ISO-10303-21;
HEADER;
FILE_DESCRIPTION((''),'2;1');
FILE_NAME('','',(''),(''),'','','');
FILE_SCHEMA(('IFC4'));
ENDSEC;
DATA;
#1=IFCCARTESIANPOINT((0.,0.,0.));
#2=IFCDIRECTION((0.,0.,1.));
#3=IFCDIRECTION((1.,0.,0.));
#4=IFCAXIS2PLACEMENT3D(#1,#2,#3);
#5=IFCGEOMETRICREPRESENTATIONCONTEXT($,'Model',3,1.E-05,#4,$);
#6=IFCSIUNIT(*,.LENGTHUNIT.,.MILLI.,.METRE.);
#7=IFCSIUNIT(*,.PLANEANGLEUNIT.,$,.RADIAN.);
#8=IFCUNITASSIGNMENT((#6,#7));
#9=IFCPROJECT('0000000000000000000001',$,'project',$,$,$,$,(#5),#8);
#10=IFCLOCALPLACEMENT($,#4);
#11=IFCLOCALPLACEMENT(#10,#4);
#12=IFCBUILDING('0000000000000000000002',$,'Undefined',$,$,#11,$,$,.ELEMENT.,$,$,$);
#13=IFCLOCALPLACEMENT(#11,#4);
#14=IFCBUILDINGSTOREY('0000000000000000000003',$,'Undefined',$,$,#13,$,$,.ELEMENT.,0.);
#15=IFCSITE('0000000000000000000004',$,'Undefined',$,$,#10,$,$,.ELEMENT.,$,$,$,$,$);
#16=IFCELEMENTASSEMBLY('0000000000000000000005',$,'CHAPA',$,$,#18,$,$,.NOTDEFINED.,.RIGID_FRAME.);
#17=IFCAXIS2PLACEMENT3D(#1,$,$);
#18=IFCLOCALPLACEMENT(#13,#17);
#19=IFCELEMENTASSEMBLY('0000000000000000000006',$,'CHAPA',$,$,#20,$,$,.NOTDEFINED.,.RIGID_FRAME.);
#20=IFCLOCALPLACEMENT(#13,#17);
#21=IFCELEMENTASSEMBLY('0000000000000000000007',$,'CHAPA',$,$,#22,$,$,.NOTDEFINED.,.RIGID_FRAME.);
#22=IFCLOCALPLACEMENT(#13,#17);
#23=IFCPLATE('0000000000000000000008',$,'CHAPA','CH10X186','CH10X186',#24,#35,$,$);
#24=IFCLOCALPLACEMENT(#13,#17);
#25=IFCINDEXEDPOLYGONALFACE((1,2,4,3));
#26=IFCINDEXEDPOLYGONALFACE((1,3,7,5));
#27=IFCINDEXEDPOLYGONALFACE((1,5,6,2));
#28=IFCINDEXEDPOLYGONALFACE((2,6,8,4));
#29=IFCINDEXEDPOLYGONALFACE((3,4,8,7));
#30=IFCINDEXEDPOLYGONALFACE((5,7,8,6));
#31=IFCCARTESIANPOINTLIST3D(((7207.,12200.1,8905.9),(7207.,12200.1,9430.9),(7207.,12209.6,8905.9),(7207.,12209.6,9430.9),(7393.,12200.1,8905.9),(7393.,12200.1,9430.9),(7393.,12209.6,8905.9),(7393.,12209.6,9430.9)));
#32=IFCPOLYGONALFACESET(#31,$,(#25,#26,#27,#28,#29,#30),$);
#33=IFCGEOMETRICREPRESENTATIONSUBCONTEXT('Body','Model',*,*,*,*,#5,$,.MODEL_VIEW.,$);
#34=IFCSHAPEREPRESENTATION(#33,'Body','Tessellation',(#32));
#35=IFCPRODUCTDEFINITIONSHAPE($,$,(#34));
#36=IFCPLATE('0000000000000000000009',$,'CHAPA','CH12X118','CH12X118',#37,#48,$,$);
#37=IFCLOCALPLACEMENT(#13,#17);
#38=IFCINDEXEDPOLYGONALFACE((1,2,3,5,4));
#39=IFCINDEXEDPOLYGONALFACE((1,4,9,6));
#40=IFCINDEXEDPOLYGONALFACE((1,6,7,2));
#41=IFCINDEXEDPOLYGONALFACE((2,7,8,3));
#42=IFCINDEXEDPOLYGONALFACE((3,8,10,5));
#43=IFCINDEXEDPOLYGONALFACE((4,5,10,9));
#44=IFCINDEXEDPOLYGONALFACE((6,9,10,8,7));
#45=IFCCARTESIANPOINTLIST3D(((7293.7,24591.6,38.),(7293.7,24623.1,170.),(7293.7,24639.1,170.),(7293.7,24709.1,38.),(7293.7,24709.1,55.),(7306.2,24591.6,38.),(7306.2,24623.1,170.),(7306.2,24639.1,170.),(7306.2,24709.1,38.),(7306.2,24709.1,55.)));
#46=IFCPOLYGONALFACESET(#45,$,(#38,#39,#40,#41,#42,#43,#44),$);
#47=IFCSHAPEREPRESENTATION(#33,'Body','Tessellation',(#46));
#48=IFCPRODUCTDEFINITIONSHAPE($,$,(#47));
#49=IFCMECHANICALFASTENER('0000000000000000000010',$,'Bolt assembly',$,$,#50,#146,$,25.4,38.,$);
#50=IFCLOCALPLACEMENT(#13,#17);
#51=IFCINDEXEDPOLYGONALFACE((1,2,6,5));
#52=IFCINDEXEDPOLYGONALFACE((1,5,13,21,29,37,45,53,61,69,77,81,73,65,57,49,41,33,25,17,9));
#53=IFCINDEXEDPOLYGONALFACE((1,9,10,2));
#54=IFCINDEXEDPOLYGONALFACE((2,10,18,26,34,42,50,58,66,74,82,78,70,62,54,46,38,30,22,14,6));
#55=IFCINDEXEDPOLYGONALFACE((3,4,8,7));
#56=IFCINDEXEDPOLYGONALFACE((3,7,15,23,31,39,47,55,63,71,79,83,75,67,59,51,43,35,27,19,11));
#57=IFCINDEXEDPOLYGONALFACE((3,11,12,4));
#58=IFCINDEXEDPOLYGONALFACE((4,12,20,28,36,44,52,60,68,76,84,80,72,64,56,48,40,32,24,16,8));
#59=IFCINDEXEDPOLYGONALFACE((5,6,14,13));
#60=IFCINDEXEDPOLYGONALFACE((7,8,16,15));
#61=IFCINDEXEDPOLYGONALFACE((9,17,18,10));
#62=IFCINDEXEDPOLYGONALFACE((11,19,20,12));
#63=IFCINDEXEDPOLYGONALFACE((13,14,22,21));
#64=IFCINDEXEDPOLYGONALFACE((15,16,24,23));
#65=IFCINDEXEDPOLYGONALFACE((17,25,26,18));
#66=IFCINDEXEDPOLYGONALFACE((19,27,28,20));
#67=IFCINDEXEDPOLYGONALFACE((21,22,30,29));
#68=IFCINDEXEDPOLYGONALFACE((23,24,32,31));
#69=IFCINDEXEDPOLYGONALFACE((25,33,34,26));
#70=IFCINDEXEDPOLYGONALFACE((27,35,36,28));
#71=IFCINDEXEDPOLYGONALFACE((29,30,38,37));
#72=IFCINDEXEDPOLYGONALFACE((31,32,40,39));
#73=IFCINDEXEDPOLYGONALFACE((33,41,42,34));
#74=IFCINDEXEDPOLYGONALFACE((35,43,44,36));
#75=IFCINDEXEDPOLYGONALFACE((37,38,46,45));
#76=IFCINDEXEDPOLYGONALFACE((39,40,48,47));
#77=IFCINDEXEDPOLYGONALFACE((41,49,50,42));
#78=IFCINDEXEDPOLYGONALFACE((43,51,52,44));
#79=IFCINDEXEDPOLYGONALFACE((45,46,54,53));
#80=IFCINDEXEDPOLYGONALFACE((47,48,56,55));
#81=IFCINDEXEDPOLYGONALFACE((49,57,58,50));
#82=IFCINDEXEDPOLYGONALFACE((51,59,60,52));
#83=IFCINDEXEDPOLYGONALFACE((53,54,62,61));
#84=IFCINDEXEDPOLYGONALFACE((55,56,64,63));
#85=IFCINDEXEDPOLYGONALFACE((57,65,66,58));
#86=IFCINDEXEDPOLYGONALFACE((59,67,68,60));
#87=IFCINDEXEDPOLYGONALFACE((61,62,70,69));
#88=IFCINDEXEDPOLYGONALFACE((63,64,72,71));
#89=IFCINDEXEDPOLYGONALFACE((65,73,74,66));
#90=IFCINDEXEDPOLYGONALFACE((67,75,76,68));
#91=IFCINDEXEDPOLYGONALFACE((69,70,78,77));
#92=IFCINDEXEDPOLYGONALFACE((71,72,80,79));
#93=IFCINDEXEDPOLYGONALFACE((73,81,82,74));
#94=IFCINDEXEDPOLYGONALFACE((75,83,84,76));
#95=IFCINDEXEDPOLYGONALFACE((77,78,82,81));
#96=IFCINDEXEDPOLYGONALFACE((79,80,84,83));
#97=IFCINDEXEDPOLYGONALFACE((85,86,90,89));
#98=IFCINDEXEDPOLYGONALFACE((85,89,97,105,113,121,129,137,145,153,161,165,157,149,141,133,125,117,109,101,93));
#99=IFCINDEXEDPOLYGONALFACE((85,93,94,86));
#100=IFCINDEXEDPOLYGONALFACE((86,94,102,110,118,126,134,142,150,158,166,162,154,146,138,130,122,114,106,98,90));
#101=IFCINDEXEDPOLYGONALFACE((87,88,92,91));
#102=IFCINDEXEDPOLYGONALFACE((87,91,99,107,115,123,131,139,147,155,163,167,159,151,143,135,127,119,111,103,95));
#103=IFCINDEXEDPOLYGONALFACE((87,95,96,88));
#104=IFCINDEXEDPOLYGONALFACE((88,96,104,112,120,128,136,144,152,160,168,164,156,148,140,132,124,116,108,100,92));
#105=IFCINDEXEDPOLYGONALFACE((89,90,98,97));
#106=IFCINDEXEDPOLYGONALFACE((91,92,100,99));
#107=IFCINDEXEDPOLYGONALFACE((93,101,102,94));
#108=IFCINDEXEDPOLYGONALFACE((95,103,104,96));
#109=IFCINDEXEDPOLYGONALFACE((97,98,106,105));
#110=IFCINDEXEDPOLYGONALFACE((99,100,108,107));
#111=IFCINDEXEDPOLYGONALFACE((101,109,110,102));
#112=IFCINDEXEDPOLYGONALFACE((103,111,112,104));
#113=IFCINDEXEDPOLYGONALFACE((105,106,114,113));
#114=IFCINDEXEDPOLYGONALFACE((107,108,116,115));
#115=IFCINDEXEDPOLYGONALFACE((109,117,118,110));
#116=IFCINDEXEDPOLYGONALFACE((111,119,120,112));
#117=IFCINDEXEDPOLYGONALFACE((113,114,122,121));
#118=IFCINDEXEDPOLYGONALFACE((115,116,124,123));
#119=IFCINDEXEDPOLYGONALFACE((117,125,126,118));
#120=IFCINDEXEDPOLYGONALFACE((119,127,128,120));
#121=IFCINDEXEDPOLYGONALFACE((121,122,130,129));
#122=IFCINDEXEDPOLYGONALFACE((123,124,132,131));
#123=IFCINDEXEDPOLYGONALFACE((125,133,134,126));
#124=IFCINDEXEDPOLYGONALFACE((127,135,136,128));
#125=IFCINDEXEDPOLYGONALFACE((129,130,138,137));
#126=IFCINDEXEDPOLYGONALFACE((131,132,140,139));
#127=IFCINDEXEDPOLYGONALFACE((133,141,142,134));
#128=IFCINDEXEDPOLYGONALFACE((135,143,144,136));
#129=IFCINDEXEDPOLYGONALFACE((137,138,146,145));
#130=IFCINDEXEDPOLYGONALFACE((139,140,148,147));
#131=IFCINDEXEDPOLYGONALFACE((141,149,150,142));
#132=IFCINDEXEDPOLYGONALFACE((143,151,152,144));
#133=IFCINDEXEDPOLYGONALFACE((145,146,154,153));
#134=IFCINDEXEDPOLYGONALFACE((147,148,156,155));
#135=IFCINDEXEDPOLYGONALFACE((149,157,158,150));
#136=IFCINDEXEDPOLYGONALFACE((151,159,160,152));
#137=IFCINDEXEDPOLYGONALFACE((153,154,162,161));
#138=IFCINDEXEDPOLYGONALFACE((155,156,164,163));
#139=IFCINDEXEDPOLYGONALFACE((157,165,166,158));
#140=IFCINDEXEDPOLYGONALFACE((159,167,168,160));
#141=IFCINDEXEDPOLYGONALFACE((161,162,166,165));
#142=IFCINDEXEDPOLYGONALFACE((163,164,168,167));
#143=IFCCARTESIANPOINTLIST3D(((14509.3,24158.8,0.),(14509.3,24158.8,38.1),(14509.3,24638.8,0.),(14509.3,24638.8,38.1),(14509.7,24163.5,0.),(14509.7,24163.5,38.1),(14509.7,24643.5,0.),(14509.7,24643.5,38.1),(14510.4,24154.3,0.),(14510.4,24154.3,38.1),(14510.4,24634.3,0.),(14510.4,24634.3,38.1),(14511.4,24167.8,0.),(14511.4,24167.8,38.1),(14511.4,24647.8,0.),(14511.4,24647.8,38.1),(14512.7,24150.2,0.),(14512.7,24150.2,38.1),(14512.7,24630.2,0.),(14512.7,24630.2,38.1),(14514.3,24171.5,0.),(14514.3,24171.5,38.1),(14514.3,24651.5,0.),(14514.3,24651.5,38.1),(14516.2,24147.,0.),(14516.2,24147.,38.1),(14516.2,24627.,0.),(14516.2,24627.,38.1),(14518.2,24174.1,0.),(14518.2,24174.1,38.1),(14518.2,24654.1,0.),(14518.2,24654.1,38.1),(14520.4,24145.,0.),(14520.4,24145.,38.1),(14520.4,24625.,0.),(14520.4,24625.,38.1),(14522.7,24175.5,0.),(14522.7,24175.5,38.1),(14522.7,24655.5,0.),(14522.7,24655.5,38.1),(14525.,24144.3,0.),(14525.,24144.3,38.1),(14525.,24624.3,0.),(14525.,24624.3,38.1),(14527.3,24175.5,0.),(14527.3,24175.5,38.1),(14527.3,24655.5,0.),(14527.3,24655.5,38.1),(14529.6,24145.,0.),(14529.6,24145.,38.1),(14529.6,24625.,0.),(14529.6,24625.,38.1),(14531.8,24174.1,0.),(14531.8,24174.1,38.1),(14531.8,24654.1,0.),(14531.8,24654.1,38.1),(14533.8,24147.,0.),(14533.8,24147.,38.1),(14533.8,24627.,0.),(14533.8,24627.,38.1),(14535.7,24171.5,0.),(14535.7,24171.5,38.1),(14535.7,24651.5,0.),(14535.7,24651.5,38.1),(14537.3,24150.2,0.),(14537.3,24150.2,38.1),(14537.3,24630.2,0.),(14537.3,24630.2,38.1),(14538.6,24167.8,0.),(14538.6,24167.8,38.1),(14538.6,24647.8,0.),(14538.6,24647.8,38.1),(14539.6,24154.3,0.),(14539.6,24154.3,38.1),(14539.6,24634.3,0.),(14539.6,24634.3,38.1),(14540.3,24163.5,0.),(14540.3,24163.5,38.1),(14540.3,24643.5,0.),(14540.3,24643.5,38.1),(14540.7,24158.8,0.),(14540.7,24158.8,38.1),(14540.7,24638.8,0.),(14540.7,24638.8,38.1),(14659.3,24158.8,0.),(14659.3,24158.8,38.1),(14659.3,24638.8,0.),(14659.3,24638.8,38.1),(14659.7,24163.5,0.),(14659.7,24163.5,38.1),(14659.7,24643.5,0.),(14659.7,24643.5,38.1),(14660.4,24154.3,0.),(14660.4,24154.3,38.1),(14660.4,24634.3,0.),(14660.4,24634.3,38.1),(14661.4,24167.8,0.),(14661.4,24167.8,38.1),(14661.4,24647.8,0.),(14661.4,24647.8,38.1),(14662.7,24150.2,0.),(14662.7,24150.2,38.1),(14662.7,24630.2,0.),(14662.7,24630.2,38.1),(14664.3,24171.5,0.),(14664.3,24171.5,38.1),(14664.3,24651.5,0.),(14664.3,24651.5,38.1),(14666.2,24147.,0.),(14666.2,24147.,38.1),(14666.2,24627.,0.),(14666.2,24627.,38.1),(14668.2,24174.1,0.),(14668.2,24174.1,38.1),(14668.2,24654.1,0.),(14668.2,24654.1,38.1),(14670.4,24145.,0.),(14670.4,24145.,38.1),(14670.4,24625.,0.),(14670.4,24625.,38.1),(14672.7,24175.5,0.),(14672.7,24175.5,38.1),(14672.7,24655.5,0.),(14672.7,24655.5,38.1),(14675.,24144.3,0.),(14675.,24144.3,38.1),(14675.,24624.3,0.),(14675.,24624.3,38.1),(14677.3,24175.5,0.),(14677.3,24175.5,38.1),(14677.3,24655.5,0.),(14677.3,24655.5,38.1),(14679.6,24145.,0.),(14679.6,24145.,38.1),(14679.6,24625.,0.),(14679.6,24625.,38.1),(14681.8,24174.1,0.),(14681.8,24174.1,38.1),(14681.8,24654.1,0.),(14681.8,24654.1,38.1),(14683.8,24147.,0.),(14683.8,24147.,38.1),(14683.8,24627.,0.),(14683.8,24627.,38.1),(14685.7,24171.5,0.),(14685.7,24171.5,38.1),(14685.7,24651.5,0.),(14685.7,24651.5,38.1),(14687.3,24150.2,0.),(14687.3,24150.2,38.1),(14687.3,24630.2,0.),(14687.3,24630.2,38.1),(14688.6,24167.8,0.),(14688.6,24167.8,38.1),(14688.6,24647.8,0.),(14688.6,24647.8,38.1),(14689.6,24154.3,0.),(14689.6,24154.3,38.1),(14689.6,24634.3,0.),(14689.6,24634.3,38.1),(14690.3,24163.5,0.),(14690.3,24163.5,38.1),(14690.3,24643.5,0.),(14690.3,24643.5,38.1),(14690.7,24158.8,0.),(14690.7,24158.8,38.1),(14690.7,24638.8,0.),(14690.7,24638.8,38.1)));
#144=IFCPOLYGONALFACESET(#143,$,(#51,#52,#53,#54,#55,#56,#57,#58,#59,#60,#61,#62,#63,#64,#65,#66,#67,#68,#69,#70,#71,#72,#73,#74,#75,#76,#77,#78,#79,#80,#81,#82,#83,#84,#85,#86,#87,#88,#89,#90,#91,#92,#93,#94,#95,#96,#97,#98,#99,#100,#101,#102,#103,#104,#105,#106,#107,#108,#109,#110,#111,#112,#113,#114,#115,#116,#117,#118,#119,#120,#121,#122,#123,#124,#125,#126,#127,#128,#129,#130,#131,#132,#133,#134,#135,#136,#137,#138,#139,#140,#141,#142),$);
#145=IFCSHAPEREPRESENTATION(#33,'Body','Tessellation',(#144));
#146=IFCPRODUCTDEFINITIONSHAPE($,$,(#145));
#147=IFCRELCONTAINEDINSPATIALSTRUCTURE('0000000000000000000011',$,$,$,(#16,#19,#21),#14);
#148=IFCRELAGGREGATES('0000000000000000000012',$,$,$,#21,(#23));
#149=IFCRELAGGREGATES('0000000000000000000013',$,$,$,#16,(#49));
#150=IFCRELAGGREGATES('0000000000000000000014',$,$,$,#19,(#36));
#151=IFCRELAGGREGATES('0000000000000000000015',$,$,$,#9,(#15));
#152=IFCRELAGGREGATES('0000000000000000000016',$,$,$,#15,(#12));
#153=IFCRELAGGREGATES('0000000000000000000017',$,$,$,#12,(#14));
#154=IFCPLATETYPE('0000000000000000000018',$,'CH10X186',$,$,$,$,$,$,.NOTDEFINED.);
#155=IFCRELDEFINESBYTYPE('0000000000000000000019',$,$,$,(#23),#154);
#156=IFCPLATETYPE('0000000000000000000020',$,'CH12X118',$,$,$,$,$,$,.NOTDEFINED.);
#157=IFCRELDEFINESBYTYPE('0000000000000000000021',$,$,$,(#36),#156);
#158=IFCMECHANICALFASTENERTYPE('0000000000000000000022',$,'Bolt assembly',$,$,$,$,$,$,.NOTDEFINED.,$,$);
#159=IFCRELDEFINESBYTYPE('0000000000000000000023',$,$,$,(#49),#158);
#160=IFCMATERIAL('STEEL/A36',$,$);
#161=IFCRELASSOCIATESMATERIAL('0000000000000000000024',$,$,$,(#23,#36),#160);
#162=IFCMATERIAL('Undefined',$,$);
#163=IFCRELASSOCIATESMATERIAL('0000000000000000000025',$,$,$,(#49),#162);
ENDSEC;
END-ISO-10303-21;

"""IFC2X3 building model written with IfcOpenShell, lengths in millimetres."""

from ifc_helpers import new_model, si_unit, frame, origin_with_axes, origin_2d_with_axis, place, context, subcontext, project, spatial, polyline, circle, outline, extrude, source, transform, mapped, material, type_object, element, aggregate, save


model = new_model("IFC2X3")

# Units and contexts
model_context = context("Model", 3, precision=1e-05, world=origin_with_axes())
body_context = subcontext(model_context, "Body", "Model", "MODEL_VIEW")
ifc_project = project(units=[si_unit("LENGTHUNIT", "METRE", prefix="MILLI"), si_unit("PLANEANGLEUNIT", "RADIAN")], contexts=[model_context])

# Site, building, storey
site_placement = place(None, origin_with_axes())
site = spatial("IfcSite", under=ifc_project, at=site_placement, Name="Undefined", CompositionType="ELEMENT")
building_placement = place(site_placement, origin_with_axes())
building = spatial("IfcBuilding", under=site, at=building_placement, Name="Undefined", CompositionType="ELEMENT")
storey_placement = place(building_placement, origin_with_axes())
storey = spatial("IfcBuildingStorey", under=building, at=storey_placement, Name="Undefined", CompositionType="ELEMENT", Elevation=0.0)

# Element assemblies
assembly_1_placement = place(storey_placement, origin_with_axes())
assembly_1 = element("IfcElementAssembly", 1, at=assembly_1_placement, inside=storey, Name="CHAPA", AssemblyPlace="NOTDEFINED", PredefinedType="RIGID_FRAME")
assembly_2_placement = place(storey_placement, origin_with_axes())
assembly_2 = element("IfcElementAssembly", 2, at=assembly_2_placement, inside=storey, Name="CHAPA", AssemblyPlace="NOTDEFINED", PredefinedType="RIGID_FRAME")

# Shared definitions
ifc_material_1 = material(Name="STEEL/A36")

# Element assembly
assembly_3_placement = place(storey_placement, origin_with_axes())
assembly_3 = element("IfcElementAssembly", 3, at=assembly_3_placement, inside=storey, Name="CHAPA", AssemblyPlace="NOTDEFINED", PredefinedType="RIGID_FRAME")

# Plates
plate_type_1 = type_object("IfcPlateType", Name="CH10X186", PredefinedType="NOTDEFINED")
plate_1_placement = place(assembly_3_placement, frame((7393.0, 12204.8, 9430.9), z_axis=(0.0, -1.0, 0.0), x_axis=(-1.0, 0.0, 0.0)))
plate_1 = element("IfcPlate", 4, at=plate_1_placement, type_object=plate_type_1, material=ifc_material_1, Name="CHAPA", Description="CH10X186", ObjectType="CH10X186", context=body_context, shape_type="SweptSolid", body=[
    extrude(outline(polyline([(0.0, 0.0), (186.0, 0.0), (186.0, 525.0), (0.0, 525.0), (0.0, 0.0)])), frame((0.0, 0.0, -4.8), z_axis=(0.0, 0.0, 1.0), x_axis=(1.0, 0.0, 0.0)), (0.0, 0.0, 1.0), 9.5),
])
aggregate(assembly_3, [plate_1])
plate_type_2 = type_object("IfcPlateType", Name="CH12X118", PredefinedType="NOTDEFINED")
plate_2_placement = place(assembly_2_placement, frame((7300.0, 24709.1, 38.0), z_axis=(-1.0, 0.0, 0.0), x_axis=(0.0, -1.0, 0.0)))
plate_2 = element("IfcPlate", 5, at=plate_2_placement, type_object=plate_type_2, material=ifc_material_1, Name="CHAPA", Description="CH12X118", ObjectType="CH12X118", context=body_context, shape_type="SweptSolid", body=[
    extrude(outline(polyline([(0.0, 0.0), (117.5, 0.0), (85.9, 132.0), (70.0, 132.0), (0.0, 17.0), (0.0, 0.0)])), frame((0.0, 0.0, -6.2), z_axis=(0.0, 0.0, 1.0), x_axis=(1.0, 0.0, 0.0)), (0.0, 0.0, 1.0), 12.5),
])

# Shared definitions
ifc_material_2 = material(Name="Undefined")
mechanical_fastener_type = type_object("IfcMechanicalFastenerType", Name="Bolt assembly")

# Mechanical fastener
shared_shape_1 = source(origin_with_axes(), body_context, "Body", "SweptSolid", [
    extrude(circle(Radius=15.7, at=origin_2d_with_axis()), frame((0.0, -38.0, 0.0), z_axis=(0.0, 1.0, 0.0), x_axis=(1.0, 0.0, 0.0)), (0.0, 0.0, 1.0), 38.1),
])
mechanical_fastener_1_placement = place(assembly_1_placement, frame((14600.0, 24640.0, 38.0), z_axis=(-1.0, 0.0, 0.0), x_axis=(0.0, -1.0, 0.0)))
mechanical_fastener_1 = element("IfcMechanicalFastener", 6, at=mechanical_fastener_1_placement, type_object=mechanical_fastener_type, material=ifc_material_2, Name="Bolt assembly", NominalDiameter=25.4, NominalLength=38.0, context=body_context, shape_type="MappedRepresentation", body=[
    mapped(shared_shape_1, transform((0.0, 0.0, -75.0))),
    mapped(shared_shape_1, transform((0.0, 0.0, 75.0))),
    mapped(shared_shape_1, transform((480.0, 0.0, -75.0))),
    mapped(shared_shape_1, transform((480.0, 0.0, 75.0))),
])
aggregate(assembly_1, [mechanical_fastener_1])
aggregate(assembly_2, [plate_2])

save(model, "model.ifc")
